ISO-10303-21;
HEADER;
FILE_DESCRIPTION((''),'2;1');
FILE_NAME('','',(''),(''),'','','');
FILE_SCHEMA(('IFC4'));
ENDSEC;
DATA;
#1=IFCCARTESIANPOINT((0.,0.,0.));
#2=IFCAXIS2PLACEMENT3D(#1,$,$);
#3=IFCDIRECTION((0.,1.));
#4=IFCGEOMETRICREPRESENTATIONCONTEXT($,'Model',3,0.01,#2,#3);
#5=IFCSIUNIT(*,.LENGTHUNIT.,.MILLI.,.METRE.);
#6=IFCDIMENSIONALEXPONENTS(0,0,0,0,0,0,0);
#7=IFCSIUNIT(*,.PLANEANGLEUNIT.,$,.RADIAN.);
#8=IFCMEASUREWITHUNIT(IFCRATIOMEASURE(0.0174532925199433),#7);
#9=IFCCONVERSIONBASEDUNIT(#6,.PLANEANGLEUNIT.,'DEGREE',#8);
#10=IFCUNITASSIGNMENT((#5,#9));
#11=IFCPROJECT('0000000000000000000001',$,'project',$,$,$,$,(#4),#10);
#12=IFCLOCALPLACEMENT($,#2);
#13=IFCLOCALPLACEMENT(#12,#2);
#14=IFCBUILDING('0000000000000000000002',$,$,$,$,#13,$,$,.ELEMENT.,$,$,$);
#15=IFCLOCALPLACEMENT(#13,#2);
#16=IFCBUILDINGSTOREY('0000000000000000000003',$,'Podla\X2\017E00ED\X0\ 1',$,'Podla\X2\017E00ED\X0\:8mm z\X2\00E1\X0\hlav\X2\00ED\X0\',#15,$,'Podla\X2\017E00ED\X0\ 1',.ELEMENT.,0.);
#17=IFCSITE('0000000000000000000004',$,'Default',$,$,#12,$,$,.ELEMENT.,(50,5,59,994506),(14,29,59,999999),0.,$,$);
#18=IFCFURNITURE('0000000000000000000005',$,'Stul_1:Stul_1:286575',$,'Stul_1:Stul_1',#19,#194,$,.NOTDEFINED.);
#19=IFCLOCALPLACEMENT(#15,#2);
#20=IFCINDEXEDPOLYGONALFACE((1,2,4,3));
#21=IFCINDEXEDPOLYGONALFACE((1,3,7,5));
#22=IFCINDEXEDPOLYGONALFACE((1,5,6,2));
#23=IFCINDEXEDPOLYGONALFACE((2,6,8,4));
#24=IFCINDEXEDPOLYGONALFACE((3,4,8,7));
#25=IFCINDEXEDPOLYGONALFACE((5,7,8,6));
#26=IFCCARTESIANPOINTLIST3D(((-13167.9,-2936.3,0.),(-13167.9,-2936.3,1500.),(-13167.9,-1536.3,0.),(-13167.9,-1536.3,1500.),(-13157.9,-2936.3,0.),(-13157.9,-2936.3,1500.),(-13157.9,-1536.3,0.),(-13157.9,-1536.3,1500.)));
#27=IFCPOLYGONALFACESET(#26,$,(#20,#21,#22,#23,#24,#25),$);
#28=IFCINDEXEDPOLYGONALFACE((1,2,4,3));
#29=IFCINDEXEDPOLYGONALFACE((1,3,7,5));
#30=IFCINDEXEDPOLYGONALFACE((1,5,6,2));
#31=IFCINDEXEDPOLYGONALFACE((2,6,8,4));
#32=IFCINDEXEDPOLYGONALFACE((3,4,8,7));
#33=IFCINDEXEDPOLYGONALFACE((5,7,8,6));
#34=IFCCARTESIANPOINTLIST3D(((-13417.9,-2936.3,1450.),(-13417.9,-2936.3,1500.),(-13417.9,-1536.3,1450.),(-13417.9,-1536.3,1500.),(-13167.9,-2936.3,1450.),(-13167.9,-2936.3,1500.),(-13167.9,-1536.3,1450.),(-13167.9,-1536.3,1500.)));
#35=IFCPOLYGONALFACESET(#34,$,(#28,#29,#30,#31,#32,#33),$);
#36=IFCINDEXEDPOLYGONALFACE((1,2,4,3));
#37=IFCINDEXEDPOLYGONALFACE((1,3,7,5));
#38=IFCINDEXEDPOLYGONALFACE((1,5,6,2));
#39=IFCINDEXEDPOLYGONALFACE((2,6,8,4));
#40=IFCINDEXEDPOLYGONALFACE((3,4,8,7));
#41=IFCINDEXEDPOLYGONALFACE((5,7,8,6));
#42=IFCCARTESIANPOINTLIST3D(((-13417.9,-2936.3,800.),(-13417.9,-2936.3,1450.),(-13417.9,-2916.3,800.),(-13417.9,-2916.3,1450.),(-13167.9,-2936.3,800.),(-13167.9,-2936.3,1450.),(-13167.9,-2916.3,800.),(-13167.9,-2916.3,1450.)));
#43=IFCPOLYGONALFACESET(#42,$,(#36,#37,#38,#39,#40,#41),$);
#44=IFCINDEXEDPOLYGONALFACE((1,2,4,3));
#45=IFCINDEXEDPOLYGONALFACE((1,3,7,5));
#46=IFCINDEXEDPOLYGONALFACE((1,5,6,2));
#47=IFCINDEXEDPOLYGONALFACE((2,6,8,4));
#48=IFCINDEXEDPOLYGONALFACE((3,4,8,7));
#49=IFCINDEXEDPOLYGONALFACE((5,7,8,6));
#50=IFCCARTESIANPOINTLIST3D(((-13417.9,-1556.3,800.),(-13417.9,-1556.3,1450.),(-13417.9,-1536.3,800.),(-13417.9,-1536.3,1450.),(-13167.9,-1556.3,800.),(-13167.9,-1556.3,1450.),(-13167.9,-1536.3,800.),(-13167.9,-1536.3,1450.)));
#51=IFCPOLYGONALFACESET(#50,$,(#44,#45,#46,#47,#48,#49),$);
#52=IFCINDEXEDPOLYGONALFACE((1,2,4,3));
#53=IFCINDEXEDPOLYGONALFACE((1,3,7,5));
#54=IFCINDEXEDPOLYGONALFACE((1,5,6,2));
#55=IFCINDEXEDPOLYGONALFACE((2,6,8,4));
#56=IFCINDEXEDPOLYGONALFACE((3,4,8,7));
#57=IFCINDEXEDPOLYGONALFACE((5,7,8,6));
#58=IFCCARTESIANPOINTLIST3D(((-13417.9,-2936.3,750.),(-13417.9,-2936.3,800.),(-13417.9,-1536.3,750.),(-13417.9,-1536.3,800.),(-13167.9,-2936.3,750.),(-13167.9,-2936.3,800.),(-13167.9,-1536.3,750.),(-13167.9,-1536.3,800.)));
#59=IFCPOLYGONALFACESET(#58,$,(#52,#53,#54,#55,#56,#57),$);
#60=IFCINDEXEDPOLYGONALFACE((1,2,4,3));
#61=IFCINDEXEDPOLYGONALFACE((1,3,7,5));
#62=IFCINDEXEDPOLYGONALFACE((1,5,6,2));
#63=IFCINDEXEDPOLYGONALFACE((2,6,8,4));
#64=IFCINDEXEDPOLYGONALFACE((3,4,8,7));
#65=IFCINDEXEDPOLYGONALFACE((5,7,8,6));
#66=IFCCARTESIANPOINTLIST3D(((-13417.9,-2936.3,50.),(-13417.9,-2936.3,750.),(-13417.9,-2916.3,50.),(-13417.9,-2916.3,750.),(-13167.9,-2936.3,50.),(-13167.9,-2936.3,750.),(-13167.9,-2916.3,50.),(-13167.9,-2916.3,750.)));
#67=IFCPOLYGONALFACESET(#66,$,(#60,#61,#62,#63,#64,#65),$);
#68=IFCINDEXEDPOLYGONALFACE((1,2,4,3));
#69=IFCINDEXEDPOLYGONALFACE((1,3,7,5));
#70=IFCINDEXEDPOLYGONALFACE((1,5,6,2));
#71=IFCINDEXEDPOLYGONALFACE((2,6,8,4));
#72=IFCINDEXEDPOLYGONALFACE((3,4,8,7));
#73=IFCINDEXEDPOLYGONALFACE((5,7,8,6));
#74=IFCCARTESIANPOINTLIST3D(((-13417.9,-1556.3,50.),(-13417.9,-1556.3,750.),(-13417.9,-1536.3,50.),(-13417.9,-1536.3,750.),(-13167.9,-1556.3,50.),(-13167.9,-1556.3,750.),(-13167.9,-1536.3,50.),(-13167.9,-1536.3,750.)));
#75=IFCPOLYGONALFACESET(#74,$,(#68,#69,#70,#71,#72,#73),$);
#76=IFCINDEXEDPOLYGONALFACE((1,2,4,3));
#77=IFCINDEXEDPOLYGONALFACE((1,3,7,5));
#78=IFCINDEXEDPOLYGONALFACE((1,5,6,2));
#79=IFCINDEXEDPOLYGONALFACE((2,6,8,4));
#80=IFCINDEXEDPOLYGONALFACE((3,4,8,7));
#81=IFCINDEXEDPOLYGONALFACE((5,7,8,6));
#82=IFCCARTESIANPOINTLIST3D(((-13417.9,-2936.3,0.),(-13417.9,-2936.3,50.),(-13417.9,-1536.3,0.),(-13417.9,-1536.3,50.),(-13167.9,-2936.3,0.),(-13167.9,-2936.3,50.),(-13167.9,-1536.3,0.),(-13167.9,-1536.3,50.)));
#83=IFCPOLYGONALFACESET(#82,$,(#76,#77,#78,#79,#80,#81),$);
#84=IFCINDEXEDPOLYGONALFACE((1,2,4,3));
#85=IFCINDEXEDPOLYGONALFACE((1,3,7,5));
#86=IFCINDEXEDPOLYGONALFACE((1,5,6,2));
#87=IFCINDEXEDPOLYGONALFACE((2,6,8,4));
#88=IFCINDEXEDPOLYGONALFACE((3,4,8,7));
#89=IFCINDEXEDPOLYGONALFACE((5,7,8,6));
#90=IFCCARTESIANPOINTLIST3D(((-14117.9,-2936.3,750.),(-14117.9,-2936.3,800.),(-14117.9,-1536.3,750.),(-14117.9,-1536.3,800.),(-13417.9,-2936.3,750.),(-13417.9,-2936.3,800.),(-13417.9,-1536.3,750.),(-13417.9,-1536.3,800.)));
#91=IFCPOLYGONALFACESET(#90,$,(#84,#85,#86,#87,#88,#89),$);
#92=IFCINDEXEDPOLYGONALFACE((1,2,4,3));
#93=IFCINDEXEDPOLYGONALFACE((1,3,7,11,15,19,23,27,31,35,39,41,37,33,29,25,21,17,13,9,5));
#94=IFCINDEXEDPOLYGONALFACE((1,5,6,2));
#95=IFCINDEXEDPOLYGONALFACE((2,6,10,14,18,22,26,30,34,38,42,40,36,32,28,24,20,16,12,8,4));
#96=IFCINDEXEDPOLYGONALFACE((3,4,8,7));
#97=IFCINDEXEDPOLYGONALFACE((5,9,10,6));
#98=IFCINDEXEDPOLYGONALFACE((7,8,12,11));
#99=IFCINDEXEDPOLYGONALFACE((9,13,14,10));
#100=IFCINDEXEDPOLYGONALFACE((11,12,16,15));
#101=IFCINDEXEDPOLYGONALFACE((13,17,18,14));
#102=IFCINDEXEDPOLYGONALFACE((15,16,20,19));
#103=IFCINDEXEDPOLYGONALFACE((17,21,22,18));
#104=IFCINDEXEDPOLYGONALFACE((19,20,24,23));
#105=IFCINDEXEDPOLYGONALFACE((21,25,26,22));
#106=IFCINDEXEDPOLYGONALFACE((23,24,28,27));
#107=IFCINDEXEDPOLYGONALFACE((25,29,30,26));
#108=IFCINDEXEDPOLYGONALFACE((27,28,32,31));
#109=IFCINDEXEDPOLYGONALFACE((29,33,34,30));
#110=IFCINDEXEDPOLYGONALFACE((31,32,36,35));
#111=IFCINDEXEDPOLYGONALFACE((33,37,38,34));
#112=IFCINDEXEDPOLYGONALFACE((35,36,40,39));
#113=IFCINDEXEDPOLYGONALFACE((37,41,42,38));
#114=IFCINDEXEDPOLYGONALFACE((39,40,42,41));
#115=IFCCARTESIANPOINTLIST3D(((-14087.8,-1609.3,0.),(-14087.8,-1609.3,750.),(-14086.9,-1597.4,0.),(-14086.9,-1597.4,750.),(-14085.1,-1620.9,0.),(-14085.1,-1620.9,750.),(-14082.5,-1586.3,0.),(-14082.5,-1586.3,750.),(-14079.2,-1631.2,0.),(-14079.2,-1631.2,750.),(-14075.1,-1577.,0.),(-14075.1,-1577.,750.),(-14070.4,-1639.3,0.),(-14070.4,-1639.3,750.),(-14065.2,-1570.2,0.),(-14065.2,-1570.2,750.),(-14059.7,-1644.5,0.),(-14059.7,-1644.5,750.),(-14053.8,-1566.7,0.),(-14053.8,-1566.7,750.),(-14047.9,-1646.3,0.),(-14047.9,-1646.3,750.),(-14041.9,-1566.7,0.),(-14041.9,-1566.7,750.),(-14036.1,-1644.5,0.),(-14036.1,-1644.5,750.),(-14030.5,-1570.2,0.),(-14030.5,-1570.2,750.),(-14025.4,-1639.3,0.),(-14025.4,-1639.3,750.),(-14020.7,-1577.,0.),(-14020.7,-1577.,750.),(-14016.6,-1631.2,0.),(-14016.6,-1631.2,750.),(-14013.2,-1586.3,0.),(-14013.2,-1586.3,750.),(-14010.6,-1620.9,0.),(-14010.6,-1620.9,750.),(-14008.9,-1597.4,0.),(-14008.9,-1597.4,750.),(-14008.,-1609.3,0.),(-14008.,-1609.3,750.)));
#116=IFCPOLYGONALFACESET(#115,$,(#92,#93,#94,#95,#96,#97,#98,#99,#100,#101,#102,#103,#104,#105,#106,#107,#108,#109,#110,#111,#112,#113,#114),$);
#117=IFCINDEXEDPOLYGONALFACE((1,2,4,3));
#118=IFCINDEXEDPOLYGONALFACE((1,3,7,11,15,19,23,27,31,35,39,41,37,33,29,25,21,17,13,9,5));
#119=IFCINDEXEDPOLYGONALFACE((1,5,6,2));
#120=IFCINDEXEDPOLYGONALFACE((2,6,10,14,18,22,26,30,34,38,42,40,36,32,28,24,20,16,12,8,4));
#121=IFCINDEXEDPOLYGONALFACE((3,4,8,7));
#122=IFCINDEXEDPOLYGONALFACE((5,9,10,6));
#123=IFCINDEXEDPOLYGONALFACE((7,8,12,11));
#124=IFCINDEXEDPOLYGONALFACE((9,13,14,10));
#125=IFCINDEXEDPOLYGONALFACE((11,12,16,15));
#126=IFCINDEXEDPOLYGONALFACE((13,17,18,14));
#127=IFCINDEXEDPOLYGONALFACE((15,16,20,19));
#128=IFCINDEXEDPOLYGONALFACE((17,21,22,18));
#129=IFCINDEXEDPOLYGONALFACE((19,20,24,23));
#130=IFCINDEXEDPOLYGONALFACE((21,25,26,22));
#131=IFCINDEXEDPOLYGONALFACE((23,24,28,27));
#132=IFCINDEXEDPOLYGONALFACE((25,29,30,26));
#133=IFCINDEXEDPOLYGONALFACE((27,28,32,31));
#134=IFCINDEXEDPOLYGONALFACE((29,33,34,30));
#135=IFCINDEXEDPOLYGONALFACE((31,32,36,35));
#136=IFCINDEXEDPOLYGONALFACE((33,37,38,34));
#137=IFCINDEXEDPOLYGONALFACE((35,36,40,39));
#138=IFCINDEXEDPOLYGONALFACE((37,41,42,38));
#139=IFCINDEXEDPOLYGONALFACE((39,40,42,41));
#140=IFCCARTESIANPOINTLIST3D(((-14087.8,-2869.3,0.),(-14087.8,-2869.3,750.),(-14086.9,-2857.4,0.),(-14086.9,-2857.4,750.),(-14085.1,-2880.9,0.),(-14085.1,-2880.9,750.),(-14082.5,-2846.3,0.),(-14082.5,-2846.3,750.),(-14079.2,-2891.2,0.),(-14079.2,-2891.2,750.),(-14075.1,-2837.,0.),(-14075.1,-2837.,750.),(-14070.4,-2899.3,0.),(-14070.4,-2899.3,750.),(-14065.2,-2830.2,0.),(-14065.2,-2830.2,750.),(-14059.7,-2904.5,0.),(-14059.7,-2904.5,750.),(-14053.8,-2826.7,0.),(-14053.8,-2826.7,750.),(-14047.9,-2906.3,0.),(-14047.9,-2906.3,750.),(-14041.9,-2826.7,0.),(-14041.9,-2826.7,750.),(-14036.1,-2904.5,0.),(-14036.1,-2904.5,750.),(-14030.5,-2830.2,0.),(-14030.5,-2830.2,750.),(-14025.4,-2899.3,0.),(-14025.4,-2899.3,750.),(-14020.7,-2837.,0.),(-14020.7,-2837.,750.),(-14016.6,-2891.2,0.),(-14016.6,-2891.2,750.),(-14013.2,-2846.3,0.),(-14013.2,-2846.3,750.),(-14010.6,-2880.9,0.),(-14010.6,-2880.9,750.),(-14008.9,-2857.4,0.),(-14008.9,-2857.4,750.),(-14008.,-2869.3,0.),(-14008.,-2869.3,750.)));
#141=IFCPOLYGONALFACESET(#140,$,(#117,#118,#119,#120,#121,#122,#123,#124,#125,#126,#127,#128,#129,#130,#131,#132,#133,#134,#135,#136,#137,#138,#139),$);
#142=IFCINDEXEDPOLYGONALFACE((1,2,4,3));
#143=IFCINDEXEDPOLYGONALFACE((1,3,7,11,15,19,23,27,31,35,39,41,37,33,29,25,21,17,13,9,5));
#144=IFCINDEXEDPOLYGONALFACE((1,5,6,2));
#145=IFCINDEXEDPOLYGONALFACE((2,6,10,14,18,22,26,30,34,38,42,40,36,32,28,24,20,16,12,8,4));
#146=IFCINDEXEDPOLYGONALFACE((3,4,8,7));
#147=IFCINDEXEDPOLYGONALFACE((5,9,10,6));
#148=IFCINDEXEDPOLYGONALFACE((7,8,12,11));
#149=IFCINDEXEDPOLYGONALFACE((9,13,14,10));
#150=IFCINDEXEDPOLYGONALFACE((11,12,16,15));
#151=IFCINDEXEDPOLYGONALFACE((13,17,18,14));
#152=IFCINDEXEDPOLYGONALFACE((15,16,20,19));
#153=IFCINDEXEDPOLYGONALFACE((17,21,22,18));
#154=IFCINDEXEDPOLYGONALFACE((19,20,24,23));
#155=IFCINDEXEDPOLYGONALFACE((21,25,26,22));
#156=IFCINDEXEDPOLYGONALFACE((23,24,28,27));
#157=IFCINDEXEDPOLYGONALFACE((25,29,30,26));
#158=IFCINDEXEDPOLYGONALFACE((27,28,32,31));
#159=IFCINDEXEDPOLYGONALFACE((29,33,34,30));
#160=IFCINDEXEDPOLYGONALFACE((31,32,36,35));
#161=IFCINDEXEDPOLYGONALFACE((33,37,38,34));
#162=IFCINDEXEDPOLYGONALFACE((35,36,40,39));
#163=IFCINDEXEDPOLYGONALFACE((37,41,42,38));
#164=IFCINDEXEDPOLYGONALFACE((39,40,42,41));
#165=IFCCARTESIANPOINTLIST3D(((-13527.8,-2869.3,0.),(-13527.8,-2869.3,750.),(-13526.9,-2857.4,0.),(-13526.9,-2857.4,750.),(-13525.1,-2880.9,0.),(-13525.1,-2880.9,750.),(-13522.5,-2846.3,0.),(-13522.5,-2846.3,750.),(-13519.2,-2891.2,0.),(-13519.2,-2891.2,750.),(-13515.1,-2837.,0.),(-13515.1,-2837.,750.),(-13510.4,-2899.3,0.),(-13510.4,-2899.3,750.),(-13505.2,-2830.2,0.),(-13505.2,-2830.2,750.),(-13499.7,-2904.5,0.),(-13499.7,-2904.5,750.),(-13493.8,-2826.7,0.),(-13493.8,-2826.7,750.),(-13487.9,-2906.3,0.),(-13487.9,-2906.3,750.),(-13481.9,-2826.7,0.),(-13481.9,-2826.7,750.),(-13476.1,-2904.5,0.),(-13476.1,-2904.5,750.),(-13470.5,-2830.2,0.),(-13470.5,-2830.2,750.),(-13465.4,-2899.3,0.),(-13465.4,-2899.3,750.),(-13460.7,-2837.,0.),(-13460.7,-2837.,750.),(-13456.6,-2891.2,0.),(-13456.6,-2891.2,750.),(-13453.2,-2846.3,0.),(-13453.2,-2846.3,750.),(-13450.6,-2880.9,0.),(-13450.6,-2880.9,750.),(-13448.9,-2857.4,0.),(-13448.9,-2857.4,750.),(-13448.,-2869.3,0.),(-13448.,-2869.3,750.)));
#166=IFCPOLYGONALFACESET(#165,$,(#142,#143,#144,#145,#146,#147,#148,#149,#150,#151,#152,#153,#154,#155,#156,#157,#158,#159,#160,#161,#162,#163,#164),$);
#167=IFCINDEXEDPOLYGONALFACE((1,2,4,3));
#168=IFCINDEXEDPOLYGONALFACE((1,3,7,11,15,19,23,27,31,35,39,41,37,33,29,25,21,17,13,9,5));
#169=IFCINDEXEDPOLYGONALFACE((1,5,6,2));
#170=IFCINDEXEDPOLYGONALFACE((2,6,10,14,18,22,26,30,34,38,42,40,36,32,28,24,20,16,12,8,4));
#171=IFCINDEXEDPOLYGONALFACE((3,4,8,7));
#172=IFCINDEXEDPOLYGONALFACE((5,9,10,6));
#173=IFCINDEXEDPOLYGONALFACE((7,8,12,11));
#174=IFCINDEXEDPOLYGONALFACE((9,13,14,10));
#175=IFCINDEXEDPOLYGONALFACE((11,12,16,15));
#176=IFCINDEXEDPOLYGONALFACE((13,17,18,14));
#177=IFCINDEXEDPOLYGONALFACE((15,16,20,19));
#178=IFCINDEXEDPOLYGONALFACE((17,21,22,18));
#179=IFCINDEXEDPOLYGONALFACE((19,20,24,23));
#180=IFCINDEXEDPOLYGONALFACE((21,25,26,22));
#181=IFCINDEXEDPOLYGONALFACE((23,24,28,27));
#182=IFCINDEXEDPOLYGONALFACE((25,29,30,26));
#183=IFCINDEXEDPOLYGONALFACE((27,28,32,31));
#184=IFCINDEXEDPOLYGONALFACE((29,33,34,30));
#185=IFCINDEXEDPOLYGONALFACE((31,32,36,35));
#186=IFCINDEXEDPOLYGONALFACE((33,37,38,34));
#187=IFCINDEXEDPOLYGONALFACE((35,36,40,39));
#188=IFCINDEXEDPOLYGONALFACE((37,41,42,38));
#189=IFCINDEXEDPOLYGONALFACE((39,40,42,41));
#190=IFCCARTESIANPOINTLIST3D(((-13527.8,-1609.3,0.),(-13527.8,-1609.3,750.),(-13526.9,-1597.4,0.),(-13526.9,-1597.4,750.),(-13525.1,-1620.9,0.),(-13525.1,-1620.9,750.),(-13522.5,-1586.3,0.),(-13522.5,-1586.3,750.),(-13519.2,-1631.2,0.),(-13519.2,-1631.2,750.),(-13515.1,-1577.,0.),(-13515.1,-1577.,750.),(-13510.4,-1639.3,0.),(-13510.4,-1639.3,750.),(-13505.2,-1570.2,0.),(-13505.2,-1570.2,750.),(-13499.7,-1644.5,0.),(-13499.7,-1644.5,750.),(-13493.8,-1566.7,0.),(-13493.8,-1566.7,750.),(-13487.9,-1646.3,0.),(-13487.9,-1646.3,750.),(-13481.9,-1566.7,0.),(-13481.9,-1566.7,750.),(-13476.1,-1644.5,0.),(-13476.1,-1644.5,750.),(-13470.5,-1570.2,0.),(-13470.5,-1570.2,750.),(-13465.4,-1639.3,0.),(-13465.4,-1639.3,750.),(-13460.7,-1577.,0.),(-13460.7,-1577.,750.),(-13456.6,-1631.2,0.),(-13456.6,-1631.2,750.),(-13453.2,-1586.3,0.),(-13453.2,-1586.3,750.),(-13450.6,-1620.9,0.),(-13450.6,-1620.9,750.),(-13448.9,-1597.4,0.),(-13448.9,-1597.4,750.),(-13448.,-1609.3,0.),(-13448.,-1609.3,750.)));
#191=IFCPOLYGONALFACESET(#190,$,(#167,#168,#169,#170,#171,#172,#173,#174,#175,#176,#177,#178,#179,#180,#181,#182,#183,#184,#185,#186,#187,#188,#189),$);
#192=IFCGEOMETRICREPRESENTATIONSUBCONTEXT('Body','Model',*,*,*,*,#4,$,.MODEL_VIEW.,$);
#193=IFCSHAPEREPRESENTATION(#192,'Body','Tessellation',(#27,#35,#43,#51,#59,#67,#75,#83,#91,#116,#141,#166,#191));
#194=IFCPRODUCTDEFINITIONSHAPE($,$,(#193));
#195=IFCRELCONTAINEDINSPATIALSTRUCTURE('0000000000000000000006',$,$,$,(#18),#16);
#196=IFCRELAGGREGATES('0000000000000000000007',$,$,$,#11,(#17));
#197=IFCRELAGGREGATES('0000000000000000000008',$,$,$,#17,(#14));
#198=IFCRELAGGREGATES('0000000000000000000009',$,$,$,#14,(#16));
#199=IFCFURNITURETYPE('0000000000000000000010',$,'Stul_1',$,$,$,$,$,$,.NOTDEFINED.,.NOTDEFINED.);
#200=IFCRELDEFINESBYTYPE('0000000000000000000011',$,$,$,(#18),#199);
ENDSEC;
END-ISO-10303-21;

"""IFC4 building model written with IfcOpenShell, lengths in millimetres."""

from ifc_helpers import new_model, entity, si_unit, converted_unit, direction, frame, frame_2d, origin, origin_2d_with_axis, place, context, subcontext, project, spatial, rectangle, circle, extrude, source, transform, mapped, type_object, type_shapes, element, save


model = new_model("IFC4")

# Units and contexts
model_context = context("Model", 3, precision=0.01, world=origin(), true_north=direction((0.0, 1.0)))
body_context = subcontext(model_context, "Body", "Model", "MODEL_VIEW")
ifc_project = project(units=[si_unit("LENGTHUNIT", "METRE", prefix="MILLI"), converted_unit("PLANEANGLEUNIT", "DEGREE", entity("IfcRatioMeasure", 0.0174532925199433), si_unit("PLANEANGLEUNIT", "RADIAN"), dimensions=[0, 0, 0, 0, 0, 0, 0])], contexts=[model_context])

# Site, building, storey
site_placement = place(None, origin())
site = spatial("IfcSite", under=ifc_project, at=site_placement, Name="Default", CompositionType="ELEMENT", RefLatitude=(50, 5, 59, 994506), RefLongitude=(14, 29, 59, 999999), RefElevation=0.0)
building_placement = place(site_placement, origin())
building = spatial("IfcBuilding", under=site, at=building_placement, CompositionType="ELEMENT")
storey_placement = place(building_placement, origin())
storey = spatial("IfcBuildingStorey", under=building, at=storey_placement, Name="Podlaží 1", ObjectType="Podlaží:8mm záhlaví", LongName="Podlaží 1", CompositionType="ELEMENT", Elevation=0.0)

# Furniture
furniture_type = type_object("IfcFurnitureType", Name="Stul_1", AssemblyPlace="NOTDEFINED", PredefinedType="NOTDEFINED")
shared_shape_1 = source(origin(), body_context, "Body", "SweptSolid", [
    extrude(rectangle(XDim=1400.0, YDim=10.0, at=origin_2d_with_axis()), frame((0.0, 605.0, 0.0), z_axis=(0.0, 0.0, 1.0), x_axis=(-1.0, 0.0, 0.0)), (0.0, 0.0, 1.0), 1500.0),
    extrude(rectangle(XDim=1400.0, YDim=250.0, at=frame_2d((0.0, 0.0), x_axis=(1.0, 0.0))), frame((0.0, 475.0, 1450.0), z_axis=(0.0, 0.0, 1.0), x_axis=(-1.0, 0.0, 0.0)), (0.0, 0.0, 1.0), 50.0),
    extrude(rectangle(XDim=20.0, YDim=250.0, at=origin_2d_with_axis()), frame((690.0, 475.0, 800.0), z_axis=(0.0, 0.0, 1.0), x_axis=(-1.0, 0.0, 0.0)), (0.0, 0.0, 1.0), 650.0),
    extrude(rectangle(XDim=20.0, YDim=250.0, at=frame_2d((0.0, 0.0), x_axis=(1.0, 0.0))), frame((-690.0, 475.0, 800.0), z_axis=(0.0, 0.0, 1.0), x_axis=(-1.0, 0.0, 0.0)), (0.0, 0.0, 1.0), 650.0),
    extrude(rectangle(XDim=1400.0, YDim=250.0, at=origin_2d_with_axis()), frame((0.0, 475.0, 750.0), z_axis=(0.0, 0.0, 1.0), x_axis=(-1.0, 0.0, 0.0)), (0.0, 0.0, 1.0), 50.0),
    extrude(rectangle(XDim=20.0, YDim=250.0, at=origin_2d_with_axis()), frame((690.0, 475.0, 50.0), z_axis=(0.0, 0.0, 1.0), x_axis=(-1.0, 0.0, 0.0)), (0.0, 0.0, 1.0), 700.0),
    extrude(rectangle(XDim=20.0, YDim=250.0, at=frame_2d((0.0, 0.0), x_axis=(1.0, 0.0))), frame((-690.0, 475.0, 50.0), z_axis=(0.0, 0.0, 1.0), x_axis=(-1.0, 0.0, 0.0)), (0.0, 0.0, 1.0), 700.0),
    extrude(rectangle(XDim=1400.0, YDim=250.0, at=origin_2d_with_axis()), frame((0.0, 475.0, 0.0), z_axis=(0.0, 0.0, 1.0), x_axis=(-1.0, 0.0, 0.0)), (0.0, 0.0, 1.0), 50.0),
    extrude(rectangle(XDim=1400.0, YDim=700.0, at=origin_2d_with_axis()), frame((0.0, 0.0, 750.0), z_axis=(0.0, 0.0, 1.0), x_axis=(-1.0, 0.0, 0.0)), (0.0, 0.0, 1.0), 50.0),
    extrude(circle(Radius=40.0, at=frame_2d((0.0, 0.0), x_axis=(1.0, 0.0))), frame((-630.0, -280.0, 0.0)), (0.0, 0.0, 1.0), 750.0),
    extrude(circle(Radius=40.0, at=frame_2d((0.0, 0.0), x_axis=(1.0, 0.0))), frame((630.0, -280.0, 0.0)), (0.0, 0.0, 1.0), 750.0),
    extrude(circle(Radius=40.0, at=frame_2d((0.0, 0.0), x_axis=(1.0, 0.0))), frame((630.0, 280.0, 0.0)), (0.0, 0.0, 1.0), 750.0),
    extrude(circle(Radius=40.0, at=frame_2d((0.0, 0.0), x_axis=(1.0, 0.0))), frame((-630.0, 280.0, 0.0)), (0.0, 0.0, 1.0), 750.0),
])
type_shapes(furniture_type, [shared_shape_1])
for number, where, z_axis, x_axis, name in (
    (1, (-13767.9, -2236.3, 0.0), (0.0, 0.0, 1.0), (0.0, -1.0, 0.0), "Stul_1:Stul_1:286575"),
):
    element("IfcFurniture", number, at=place(storey_placement, frame(where, z_axis=z_axis, x_axis=x_axis)), inside=storey, type_object=furniture_type, Name=name, ObjectType="Stul_1:Stul_1", PredefinedType="NOTDEFINED", context=body_context, shape_type="MappedRepresentation", body=[
        mapped(shared_shape_1, transform((0.0, 0.0, 0.0), scale=1.0)),
    ])

save(model, "model.ifc")
